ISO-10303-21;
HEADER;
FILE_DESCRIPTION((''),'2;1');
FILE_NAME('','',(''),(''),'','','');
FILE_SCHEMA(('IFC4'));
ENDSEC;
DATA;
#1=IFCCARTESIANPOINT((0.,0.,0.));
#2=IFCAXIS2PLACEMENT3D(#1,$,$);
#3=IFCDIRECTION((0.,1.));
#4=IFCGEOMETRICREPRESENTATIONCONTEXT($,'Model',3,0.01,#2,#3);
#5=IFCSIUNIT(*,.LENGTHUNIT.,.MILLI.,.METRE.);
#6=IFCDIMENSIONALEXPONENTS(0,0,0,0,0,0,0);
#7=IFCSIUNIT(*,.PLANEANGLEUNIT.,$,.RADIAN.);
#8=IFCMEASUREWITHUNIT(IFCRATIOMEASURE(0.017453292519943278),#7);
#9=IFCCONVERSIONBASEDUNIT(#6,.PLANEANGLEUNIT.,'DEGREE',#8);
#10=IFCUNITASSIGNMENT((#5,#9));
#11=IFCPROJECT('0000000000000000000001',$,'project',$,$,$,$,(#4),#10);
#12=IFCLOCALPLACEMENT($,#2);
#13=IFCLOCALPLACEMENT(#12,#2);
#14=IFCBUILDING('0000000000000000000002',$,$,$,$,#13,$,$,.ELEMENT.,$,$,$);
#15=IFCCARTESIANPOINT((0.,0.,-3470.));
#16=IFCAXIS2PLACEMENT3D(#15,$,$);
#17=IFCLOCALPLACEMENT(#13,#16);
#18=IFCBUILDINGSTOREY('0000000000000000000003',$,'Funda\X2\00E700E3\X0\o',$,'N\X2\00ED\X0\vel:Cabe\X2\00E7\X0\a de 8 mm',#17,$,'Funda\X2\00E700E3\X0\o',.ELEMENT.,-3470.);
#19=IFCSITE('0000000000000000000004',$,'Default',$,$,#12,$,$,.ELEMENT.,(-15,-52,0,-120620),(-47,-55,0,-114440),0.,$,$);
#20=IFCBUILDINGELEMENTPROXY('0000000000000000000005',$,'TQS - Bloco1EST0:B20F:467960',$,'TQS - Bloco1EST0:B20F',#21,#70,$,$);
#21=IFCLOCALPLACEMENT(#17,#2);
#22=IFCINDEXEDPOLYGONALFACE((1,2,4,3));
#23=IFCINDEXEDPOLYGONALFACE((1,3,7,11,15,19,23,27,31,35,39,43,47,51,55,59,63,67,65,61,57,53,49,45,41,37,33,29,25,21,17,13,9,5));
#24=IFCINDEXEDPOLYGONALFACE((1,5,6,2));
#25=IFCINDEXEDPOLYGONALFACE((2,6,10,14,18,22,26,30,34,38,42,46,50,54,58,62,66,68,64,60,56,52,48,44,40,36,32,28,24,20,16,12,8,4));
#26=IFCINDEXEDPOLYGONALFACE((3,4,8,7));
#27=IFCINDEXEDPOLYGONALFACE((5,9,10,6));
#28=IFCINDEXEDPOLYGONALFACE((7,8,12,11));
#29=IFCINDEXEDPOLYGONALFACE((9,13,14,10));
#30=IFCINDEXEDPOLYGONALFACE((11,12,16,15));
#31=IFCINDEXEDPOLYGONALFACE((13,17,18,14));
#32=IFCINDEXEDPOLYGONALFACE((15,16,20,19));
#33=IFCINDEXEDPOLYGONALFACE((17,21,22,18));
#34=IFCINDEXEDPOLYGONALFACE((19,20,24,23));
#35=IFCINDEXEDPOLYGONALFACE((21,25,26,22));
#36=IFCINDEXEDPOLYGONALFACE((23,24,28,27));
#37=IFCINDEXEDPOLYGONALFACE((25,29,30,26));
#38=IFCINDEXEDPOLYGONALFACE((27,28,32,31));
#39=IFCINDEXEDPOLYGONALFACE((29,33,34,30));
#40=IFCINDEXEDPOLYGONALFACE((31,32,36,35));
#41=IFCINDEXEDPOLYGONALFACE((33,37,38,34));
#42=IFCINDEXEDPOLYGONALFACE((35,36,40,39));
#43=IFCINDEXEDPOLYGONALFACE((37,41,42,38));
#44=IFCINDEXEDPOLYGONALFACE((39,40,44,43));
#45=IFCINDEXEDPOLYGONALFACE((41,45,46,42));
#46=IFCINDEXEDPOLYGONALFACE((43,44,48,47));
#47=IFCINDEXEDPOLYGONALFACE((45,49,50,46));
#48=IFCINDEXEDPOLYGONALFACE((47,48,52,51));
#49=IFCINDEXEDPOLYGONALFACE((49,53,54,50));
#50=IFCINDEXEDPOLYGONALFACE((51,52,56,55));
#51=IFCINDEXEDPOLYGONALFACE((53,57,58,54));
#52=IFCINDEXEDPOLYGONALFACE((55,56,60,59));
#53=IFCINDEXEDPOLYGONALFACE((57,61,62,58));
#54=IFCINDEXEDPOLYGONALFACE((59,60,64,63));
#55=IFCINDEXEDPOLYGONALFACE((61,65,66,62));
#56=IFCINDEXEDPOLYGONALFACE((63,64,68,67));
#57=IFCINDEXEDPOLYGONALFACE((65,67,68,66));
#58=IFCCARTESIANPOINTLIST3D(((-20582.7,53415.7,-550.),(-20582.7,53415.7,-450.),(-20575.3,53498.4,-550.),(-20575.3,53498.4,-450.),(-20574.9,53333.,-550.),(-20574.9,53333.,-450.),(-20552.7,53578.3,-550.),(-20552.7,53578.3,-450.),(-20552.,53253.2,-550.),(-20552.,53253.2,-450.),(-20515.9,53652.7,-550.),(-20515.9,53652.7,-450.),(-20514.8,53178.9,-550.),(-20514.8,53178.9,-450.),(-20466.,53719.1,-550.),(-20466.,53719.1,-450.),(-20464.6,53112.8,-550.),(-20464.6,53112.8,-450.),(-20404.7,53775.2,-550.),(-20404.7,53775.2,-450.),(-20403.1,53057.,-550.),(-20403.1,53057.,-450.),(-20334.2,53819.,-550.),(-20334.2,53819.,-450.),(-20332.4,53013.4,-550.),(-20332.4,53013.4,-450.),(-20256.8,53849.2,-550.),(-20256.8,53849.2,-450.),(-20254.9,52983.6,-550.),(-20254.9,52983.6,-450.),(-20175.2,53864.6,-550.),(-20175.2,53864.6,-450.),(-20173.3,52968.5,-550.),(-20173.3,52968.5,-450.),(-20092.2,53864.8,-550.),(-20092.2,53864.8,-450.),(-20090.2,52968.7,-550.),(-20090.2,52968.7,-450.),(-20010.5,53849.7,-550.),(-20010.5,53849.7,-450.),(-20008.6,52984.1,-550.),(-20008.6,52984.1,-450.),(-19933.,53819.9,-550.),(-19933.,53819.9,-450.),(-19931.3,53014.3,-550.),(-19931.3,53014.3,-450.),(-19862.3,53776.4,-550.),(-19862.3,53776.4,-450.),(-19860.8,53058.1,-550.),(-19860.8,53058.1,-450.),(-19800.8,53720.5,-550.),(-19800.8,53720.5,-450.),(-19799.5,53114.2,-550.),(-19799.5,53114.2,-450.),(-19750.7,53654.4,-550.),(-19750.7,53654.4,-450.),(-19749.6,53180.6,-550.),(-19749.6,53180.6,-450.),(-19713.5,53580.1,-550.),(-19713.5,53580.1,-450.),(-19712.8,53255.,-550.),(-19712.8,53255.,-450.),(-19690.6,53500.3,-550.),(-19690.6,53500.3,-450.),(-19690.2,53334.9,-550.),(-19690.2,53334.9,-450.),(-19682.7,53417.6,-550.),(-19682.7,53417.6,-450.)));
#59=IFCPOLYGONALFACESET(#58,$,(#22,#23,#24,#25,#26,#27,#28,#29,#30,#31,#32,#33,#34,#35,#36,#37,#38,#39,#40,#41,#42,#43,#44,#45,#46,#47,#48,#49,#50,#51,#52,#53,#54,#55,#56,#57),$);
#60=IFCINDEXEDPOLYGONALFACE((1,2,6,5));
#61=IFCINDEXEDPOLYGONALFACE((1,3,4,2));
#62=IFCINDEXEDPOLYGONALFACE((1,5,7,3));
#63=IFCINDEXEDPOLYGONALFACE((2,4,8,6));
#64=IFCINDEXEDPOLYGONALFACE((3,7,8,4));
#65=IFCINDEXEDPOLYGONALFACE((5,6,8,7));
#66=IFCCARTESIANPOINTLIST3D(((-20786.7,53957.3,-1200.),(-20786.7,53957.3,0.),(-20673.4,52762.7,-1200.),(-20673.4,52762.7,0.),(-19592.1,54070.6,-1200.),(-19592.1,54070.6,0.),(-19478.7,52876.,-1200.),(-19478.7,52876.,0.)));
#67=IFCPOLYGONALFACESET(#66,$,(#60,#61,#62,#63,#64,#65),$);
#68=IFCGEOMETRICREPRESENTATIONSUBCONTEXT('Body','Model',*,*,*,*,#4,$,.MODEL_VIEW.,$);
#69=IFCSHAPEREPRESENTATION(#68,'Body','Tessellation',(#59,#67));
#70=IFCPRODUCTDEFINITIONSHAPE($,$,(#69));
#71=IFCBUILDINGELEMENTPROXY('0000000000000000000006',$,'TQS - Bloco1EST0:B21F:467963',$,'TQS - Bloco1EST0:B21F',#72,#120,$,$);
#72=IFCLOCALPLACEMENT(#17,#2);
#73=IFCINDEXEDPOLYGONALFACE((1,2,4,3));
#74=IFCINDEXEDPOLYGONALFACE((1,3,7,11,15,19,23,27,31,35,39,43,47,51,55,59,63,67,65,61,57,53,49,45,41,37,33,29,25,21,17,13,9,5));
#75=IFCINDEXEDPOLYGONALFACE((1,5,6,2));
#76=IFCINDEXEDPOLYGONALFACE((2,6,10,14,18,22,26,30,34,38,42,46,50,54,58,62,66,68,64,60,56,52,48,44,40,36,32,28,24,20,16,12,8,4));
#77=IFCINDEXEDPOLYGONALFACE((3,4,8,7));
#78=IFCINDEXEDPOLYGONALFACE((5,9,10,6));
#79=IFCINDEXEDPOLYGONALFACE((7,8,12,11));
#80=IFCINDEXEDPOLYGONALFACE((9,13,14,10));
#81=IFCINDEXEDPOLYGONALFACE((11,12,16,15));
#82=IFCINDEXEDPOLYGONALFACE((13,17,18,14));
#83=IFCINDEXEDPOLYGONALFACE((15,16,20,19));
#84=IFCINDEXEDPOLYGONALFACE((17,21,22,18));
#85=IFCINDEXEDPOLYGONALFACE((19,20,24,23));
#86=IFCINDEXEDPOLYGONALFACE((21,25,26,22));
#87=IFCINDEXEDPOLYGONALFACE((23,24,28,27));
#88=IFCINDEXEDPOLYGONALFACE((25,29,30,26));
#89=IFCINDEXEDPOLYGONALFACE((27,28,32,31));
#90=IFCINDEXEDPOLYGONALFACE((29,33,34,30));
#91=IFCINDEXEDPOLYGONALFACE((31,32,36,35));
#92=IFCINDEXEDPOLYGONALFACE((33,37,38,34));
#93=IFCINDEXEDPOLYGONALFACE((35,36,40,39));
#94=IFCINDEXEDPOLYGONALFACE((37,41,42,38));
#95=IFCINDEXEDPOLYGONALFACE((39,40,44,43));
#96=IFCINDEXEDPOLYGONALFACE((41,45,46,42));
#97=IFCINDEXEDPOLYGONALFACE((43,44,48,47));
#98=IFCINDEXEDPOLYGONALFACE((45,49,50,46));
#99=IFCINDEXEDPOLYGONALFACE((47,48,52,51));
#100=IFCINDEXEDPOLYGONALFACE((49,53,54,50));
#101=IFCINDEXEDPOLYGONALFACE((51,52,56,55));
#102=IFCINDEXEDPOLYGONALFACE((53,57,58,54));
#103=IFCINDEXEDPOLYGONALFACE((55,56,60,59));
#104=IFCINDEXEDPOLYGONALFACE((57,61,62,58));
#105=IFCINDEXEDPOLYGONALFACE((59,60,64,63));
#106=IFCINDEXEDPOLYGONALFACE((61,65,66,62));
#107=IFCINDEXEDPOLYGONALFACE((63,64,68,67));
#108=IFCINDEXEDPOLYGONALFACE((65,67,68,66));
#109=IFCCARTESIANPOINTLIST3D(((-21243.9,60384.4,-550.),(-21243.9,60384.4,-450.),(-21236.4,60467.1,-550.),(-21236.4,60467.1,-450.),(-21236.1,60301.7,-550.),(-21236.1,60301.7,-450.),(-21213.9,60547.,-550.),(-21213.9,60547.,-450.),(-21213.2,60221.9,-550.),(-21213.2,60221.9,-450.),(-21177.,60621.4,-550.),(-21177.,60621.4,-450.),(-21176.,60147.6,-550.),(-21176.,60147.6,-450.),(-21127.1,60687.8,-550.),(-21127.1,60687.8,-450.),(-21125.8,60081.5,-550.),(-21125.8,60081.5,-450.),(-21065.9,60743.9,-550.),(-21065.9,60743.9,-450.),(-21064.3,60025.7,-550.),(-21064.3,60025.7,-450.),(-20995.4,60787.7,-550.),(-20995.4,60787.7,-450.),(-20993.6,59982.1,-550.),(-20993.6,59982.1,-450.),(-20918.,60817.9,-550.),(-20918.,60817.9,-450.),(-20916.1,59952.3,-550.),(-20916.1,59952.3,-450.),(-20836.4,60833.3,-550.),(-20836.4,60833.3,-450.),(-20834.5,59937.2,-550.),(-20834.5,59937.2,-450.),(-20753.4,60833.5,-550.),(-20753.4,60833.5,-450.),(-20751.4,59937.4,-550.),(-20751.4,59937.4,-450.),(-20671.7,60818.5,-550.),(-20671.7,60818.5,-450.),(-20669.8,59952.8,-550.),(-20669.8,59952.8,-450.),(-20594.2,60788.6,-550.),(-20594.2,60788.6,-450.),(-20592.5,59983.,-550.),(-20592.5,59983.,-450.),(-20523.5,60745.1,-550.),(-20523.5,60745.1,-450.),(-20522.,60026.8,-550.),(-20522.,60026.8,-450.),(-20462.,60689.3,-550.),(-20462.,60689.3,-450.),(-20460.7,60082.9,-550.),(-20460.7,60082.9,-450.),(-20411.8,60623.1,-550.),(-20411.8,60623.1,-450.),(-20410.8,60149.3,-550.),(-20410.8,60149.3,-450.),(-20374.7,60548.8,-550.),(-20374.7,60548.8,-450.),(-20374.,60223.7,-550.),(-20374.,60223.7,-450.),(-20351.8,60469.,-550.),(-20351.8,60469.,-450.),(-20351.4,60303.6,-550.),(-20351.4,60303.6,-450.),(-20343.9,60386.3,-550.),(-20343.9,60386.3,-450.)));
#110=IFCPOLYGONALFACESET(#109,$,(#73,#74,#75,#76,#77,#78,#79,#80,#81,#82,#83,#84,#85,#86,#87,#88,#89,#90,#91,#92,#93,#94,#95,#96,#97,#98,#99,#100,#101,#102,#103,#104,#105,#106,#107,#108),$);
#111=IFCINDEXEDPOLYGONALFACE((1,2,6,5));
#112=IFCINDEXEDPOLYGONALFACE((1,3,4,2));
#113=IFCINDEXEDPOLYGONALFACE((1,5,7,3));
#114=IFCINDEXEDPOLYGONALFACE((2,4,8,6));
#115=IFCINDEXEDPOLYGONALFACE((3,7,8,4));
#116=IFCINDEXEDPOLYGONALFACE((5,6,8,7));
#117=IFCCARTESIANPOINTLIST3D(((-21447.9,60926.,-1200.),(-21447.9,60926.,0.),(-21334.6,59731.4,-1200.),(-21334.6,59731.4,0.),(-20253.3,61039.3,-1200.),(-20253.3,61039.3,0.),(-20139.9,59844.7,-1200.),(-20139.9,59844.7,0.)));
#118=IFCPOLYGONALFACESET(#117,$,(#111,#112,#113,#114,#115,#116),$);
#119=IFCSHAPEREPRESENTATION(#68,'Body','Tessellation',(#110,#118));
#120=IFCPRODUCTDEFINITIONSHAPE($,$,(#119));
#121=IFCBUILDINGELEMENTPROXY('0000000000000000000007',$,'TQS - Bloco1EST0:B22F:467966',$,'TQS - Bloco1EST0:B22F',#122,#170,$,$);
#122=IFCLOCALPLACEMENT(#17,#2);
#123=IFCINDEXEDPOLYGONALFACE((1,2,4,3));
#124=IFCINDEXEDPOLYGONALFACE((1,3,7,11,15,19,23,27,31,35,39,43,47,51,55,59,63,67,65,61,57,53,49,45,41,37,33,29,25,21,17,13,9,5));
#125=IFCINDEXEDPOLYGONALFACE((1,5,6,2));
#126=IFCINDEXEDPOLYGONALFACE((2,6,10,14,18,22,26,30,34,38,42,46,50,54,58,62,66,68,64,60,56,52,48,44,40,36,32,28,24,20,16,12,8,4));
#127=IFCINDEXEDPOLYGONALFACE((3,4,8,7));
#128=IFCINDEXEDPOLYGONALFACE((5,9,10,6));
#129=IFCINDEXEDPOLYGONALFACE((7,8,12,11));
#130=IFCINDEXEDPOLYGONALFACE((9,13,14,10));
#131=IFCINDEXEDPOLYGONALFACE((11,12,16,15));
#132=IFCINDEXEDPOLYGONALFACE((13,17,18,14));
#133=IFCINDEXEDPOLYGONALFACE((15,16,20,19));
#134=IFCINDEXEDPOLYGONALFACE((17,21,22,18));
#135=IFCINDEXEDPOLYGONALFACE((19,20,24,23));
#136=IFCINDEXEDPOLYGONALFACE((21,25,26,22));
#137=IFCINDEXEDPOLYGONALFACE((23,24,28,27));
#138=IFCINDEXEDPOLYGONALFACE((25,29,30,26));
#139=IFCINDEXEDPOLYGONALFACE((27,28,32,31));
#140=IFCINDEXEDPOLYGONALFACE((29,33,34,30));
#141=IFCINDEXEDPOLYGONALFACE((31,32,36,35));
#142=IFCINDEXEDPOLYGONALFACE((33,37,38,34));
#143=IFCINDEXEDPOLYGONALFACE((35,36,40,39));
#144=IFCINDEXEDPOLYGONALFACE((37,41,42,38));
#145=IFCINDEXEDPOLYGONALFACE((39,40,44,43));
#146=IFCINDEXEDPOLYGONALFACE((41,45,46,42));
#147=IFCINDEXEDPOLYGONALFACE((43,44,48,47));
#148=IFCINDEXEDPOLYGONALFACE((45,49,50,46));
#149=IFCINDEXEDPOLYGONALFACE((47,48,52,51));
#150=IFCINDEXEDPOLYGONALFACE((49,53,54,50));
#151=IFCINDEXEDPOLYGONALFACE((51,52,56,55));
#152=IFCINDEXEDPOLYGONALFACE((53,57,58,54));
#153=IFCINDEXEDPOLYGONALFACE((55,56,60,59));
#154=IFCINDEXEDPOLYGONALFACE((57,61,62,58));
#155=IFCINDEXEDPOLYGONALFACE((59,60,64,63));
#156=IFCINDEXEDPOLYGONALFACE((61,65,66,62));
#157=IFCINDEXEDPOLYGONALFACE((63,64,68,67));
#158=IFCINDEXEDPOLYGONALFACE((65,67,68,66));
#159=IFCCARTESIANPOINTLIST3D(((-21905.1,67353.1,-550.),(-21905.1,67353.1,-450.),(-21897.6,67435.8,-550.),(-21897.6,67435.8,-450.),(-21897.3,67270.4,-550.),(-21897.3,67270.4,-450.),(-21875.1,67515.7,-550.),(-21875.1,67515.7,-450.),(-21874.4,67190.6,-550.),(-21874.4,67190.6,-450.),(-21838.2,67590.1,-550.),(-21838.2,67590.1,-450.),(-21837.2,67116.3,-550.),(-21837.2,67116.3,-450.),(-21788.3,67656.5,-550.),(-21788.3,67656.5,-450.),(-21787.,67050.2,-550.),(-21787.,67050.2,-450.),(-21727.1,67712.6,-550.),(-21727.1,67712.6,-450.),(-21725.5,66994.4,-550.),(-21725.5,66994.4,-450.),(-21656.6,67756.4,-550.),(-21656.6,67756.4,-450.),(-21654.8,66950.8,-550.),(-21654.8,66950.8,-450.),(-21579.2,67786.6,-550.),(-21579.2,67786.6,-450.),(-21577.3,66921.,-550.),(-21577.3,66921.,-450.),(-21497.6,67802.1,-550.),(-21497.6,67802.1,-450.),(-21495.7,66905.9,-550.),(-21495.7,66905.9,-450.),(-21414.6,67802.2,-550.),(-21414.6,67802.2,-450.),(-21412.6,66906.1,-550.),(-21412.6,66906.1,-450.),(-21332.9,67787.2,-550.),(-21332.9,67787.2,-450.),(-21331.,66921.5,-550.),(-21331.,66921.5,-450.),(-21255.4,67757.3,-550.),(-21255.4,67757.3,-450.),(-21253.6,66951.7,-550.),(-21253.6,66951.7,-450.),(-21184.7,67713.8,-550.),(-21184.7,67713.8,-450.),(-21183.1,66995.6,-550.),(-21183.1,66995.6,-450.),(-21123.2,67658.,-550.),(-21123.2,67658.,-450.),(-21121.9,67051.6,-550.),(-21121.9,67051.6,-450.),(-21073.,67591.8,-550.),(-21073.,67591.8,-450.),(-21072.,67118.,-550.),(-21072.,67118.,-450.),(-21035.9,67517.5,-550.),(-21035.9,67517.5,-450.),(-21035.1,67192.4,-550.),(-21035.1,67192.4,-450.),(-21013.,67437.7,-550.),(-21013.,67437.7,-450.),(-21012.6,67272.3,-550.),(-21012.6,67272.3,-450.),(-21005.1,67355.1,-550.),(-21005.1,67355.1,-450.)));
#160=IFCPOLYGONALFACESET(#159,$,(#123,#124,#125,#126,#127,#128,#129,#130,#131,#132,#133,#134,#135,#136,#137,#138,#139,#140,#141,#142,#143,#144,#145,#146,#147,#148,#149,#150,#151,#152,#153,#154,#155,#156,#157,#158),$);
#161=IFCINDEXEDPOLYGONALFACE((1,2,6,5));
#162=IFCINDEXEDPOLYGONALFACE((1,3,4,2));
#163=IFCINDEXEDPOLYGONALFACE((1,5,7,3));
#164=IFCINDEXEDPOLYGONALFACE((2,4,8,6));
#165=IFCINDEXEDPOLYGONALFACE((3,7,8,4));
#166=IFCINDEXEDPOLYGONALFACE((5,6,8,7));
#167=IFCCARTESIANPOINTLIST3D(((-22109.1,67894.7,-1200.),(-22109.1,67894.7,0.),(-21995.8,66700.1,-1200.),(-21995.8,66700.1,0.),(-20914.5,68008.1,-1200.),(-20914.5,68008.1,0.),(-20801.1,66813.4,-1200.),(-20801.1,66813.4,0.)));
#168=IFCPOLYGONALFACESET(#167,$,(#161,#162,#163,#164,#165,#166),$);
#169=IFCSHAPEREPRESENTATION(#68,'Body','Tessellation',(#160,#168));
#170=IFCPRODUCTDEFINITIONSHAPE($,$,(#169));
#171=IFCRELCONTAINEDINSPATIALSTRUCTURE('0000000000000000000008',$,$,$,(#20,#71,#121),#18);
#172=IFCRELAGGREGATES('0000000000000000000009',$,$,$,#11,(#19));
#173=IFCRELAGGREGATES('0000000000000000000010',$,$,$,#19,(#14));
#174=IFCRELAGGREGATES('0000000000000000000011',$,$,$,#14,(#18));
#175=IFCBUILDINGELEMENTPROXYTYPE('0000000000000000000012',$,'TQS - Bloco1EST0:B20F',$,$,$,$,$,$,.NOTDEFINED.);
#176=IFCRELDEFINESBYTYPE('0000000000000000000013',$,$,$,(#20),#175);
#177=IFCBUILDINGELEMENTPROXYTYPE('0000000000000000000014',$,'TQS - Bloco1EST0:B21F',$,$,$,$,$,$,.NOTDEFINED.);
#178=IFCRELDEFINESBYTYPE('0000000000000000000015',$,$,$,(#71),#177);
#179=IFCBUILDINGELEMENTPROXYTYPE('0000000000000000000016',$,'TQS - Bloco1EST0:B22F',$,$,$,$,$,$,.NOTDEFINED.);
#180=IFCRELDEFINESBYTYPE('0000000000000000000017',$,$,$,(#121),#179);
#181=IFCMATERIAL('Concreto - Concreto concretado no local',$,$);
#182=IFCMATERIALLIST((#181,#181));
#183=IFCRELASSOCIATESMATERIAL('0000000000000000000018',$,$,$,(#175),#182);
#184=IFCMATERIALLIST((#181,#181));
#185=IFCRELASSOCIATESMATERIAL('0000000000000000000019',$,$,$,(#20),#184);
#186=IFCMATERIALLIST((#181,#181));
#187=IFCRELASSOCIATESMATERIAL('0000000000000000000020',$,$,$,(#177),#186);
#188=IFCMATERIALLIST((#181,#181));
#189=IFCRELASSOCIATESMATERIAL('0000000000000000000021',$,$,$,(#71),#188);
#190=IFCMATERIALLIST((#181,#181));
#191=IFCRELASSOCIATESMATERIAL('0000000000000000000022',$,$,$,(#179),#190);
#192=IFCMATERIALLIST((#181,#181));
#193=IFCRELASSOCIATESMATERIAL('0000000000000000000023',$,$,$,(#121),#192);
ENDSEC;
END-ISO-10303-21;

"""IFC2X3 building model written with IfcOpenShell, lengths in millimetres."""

from ifc_helpers import new_model, entity, si_unit, converted_unit, direction, frame, frame_2d, origin, origin_2d_with_axis, place, context, subcontext, project, spatial, rectangle, circle, extrude, source, transform, mapped, material, material_list, type_object, type_shapes, element, save


model = new_model("IFC2X3")

# Units and contexts
model_context = context("Model", 3, precision=0.01, world=origin(), true_north=direction((0.0, 1.0)))
body_context = subcontext(model_context, "Body", "Model", "MODEL_VIEW")
ifc_project = project(units=[si_unit("LENGTHUNIT", "METRE", prefix="MILLI"), converted_unit("PLANEANGLEUNIT", "DEGREE", entity("IfcRatioMeasure", 0.017453292519943278), si_unit("PLANEANGLEUNIT", "RADIAN"), dimensions=[0, 0, 0, 0, 0, 0, 0])], contexts=[model_context])

# Site, building, storey
site_placement = place(None, origin())
site = spatial("IfcSite", under=ifc_project, at=site_placement, Name="Default", CompositionType="ELEMENT", RefLatitude=(-15, -52, 0, -120620), RefLongitude=(-47, -55, 0, -114440), RefElevation=0.0)
building_placement = place(site_placement, origin())
building = spatial("IfcBuilding", under=site, at=building_placement, CompositionType="ELEMENT")
storey_placement = place(building_placement, frame((0.0, 0.0, -3470.0)))
storey = spatial("IfcBuildingStorey", under=building, at=storey_placement, Name="Fundação", ObjectType="Nível:Cabeça de 8 mm", LongName="Fundação", CompositionType="ELEMENT", Elevation=-3470.0)

# Building element proxies
ifc_material_1 = material(Name="Concreto - Concreto concretado no local")
ifc_material_list_1 = material_list([ifc_material_1, ifc_material_1])
ifc_material_list_2 = material_list([ifc_material_1, ifc_material_1])
building_element_proxy_type_1 = type_object("IfcBuildingElementProxyType", Name="TQS - Bloco1EST0:B20F", PredefinedType="NOTDEFINED", material=ifc_material_list_2)
shared_shape_1 = source(origin(), body_context, "Body", "SweptSolid", [
    extrude(circle(Radius=450.0, at=frame_2d((0.0, 0.0), x_axis=(1.0, 0.0))), frame((0.0, 0.0, -550.0)), (0.0, 0.0, 1.0), 100.0),
    extrude(rectangle(XDim=1200.0, YDim=1200.0, at=origin_2d_with_axis()), frame((0.0, 0.0, -1200.0), z_axis=(0.0, 0.0, 1.0), x_axis=(-1.0, 0.0, 0.0)), (0.0, 0.0, 1.0), 1200.0),
])
type_shapes(building_element_proxy_type_1, [shared_shape_1])
proxy_1_placement = place(storey_placement, frame((-20132.7, 53416.7, 0.0), z_axis=(0.0, 0.0, 1.0), x_axis=(-0.094456, 0.995529, 0.0)))
element("IfcBuildingElementProxy", 1, at=proxy_1_placement, inside=storey, type_object=building_element_proxy_type_1, material=ifc_material_list_1, Name="TQS - Bloco1EST0:B20F:467960", ObjectType="TQS - Bloco1EST0:B20F", context=body_context, shape_type="MappedRepresentation", body=[
    mapped(shared_shape_1, transform((0.0, 0.0, 0.0), scale=1.0)),
])
ifc_material_list_3 = material_list([ifc_material_1, ifc_material_1])
ifc_material_list_4 = material_list([ifc_material_1, ifc_material_1])
building_element_proxy_type_2 = type_object("IfcBuildingElementProxyType", Name="TQS - Bloco1EST0:B21F", PredefinedType="NOTDEFINED", material=ifc_material_list_4)
shared_shape_2 = source(origin(), body_context, "Body", "SweptSolid", [
    extrude(circle(Radius=450.0, at=frame_2d((0.0, 0.0), x_axis=(1.0, 0.0))), frame((0.0, 0.0, -550.0)), (0.0, 0.0, 1.0), 100.0),
    extrude(rectangle(XDim=1200.0, YDim=1200.0, at=origin_2d_with_axis()), frame((0.0, 0.0, -1200.0), z_axis=(0.0, 0.0, 1.0), x_axis=(-1.0, 0.0, 0.0)), (0.0, 0.0, 1.0), 1200.0),
])
type_shapes(building_element_proxy_type_2, [shared_shape_2])
proxy_2_placement = place(storey_placement, frame((-20793.9, 60385.4, 0.0), z_axis=(0.0, 0.0, 1.0), x_axis=(-0.094456, 0.995529, 0.0)))
element("IfcBuildingElementProxy", 2, at=proxy_2_placement, inside=storey, type_object=building_element_proxy_type_2, material=ifc_material_list_3, Name="TQS - Bloco1EST0:B21F:467963", ObjectType="TQS - Bloco1EST0:B21F", context=body_context, shape_type="MappedRepresentation", body=[
    mapped(shared_shape_2, transform((0.0, 0.0, 0.0), scale=1.0)),
])
ifc_material_list_5 = material_list([ifc_material_1, ifc_material_1])
ifc_material_list_6 = material_list([ifc_material_1, ifc_material_1])
building_element_proxy_type_3 = type_object("IfcBuildingElementProxyType", Name="TQS - Bloco1EST0:B22F", PredefinedType="NOTDEFINED", material=ifc_material_list_6)
shared_shape_3 = source(origin(), body_context, "Body", "SweptSolid", [
    extrude(circle(Radius=450.0, at=frame_2d((0.0, 0.0), x_axis=(1.0, 0.0))), frame((0.0, 0.0, -550.0)), (0.0, 0.0, 1.0), 100.0),
    extrude(rectangle(XDim=1200.0, YDim=1200.0, at=origin_2d_with_axis()), frame((0.0, 0.0, -1200.0), z_axis=(0.0, 0.0, 1.0), x_axis=(-1.0, 0.0, 0.0)), (0.0, 0.0, 1.0), 1200.0),
])
type_shapes(building_element_proxy_type_3, [shared_shape_3])
proxy_3_placement = place(storey_placement, frame((-21455.1, 67354.1, 0.0), z_axis=(0.0, 0.0, 1.0), x_axis=(-0.094456, 0.995529, 0.0)))
element("IfcBuildingElementProxy", 3, at=proxy_3_placement, inside=storey, type_object=building_element_proxy_type_3, material=ifc_material_list_5, Name="TQS - Bloco1EST0:B22F:467966", ObjectType="TQS - Bloco1EST0:B22F", context=body_context, shape_type="MappedRepresentation", body=[
    mapped(shared_shape_3, transform((0.0, 0.0, 0.0), scale=1.0)),
])

save(model, "model.ifc")
